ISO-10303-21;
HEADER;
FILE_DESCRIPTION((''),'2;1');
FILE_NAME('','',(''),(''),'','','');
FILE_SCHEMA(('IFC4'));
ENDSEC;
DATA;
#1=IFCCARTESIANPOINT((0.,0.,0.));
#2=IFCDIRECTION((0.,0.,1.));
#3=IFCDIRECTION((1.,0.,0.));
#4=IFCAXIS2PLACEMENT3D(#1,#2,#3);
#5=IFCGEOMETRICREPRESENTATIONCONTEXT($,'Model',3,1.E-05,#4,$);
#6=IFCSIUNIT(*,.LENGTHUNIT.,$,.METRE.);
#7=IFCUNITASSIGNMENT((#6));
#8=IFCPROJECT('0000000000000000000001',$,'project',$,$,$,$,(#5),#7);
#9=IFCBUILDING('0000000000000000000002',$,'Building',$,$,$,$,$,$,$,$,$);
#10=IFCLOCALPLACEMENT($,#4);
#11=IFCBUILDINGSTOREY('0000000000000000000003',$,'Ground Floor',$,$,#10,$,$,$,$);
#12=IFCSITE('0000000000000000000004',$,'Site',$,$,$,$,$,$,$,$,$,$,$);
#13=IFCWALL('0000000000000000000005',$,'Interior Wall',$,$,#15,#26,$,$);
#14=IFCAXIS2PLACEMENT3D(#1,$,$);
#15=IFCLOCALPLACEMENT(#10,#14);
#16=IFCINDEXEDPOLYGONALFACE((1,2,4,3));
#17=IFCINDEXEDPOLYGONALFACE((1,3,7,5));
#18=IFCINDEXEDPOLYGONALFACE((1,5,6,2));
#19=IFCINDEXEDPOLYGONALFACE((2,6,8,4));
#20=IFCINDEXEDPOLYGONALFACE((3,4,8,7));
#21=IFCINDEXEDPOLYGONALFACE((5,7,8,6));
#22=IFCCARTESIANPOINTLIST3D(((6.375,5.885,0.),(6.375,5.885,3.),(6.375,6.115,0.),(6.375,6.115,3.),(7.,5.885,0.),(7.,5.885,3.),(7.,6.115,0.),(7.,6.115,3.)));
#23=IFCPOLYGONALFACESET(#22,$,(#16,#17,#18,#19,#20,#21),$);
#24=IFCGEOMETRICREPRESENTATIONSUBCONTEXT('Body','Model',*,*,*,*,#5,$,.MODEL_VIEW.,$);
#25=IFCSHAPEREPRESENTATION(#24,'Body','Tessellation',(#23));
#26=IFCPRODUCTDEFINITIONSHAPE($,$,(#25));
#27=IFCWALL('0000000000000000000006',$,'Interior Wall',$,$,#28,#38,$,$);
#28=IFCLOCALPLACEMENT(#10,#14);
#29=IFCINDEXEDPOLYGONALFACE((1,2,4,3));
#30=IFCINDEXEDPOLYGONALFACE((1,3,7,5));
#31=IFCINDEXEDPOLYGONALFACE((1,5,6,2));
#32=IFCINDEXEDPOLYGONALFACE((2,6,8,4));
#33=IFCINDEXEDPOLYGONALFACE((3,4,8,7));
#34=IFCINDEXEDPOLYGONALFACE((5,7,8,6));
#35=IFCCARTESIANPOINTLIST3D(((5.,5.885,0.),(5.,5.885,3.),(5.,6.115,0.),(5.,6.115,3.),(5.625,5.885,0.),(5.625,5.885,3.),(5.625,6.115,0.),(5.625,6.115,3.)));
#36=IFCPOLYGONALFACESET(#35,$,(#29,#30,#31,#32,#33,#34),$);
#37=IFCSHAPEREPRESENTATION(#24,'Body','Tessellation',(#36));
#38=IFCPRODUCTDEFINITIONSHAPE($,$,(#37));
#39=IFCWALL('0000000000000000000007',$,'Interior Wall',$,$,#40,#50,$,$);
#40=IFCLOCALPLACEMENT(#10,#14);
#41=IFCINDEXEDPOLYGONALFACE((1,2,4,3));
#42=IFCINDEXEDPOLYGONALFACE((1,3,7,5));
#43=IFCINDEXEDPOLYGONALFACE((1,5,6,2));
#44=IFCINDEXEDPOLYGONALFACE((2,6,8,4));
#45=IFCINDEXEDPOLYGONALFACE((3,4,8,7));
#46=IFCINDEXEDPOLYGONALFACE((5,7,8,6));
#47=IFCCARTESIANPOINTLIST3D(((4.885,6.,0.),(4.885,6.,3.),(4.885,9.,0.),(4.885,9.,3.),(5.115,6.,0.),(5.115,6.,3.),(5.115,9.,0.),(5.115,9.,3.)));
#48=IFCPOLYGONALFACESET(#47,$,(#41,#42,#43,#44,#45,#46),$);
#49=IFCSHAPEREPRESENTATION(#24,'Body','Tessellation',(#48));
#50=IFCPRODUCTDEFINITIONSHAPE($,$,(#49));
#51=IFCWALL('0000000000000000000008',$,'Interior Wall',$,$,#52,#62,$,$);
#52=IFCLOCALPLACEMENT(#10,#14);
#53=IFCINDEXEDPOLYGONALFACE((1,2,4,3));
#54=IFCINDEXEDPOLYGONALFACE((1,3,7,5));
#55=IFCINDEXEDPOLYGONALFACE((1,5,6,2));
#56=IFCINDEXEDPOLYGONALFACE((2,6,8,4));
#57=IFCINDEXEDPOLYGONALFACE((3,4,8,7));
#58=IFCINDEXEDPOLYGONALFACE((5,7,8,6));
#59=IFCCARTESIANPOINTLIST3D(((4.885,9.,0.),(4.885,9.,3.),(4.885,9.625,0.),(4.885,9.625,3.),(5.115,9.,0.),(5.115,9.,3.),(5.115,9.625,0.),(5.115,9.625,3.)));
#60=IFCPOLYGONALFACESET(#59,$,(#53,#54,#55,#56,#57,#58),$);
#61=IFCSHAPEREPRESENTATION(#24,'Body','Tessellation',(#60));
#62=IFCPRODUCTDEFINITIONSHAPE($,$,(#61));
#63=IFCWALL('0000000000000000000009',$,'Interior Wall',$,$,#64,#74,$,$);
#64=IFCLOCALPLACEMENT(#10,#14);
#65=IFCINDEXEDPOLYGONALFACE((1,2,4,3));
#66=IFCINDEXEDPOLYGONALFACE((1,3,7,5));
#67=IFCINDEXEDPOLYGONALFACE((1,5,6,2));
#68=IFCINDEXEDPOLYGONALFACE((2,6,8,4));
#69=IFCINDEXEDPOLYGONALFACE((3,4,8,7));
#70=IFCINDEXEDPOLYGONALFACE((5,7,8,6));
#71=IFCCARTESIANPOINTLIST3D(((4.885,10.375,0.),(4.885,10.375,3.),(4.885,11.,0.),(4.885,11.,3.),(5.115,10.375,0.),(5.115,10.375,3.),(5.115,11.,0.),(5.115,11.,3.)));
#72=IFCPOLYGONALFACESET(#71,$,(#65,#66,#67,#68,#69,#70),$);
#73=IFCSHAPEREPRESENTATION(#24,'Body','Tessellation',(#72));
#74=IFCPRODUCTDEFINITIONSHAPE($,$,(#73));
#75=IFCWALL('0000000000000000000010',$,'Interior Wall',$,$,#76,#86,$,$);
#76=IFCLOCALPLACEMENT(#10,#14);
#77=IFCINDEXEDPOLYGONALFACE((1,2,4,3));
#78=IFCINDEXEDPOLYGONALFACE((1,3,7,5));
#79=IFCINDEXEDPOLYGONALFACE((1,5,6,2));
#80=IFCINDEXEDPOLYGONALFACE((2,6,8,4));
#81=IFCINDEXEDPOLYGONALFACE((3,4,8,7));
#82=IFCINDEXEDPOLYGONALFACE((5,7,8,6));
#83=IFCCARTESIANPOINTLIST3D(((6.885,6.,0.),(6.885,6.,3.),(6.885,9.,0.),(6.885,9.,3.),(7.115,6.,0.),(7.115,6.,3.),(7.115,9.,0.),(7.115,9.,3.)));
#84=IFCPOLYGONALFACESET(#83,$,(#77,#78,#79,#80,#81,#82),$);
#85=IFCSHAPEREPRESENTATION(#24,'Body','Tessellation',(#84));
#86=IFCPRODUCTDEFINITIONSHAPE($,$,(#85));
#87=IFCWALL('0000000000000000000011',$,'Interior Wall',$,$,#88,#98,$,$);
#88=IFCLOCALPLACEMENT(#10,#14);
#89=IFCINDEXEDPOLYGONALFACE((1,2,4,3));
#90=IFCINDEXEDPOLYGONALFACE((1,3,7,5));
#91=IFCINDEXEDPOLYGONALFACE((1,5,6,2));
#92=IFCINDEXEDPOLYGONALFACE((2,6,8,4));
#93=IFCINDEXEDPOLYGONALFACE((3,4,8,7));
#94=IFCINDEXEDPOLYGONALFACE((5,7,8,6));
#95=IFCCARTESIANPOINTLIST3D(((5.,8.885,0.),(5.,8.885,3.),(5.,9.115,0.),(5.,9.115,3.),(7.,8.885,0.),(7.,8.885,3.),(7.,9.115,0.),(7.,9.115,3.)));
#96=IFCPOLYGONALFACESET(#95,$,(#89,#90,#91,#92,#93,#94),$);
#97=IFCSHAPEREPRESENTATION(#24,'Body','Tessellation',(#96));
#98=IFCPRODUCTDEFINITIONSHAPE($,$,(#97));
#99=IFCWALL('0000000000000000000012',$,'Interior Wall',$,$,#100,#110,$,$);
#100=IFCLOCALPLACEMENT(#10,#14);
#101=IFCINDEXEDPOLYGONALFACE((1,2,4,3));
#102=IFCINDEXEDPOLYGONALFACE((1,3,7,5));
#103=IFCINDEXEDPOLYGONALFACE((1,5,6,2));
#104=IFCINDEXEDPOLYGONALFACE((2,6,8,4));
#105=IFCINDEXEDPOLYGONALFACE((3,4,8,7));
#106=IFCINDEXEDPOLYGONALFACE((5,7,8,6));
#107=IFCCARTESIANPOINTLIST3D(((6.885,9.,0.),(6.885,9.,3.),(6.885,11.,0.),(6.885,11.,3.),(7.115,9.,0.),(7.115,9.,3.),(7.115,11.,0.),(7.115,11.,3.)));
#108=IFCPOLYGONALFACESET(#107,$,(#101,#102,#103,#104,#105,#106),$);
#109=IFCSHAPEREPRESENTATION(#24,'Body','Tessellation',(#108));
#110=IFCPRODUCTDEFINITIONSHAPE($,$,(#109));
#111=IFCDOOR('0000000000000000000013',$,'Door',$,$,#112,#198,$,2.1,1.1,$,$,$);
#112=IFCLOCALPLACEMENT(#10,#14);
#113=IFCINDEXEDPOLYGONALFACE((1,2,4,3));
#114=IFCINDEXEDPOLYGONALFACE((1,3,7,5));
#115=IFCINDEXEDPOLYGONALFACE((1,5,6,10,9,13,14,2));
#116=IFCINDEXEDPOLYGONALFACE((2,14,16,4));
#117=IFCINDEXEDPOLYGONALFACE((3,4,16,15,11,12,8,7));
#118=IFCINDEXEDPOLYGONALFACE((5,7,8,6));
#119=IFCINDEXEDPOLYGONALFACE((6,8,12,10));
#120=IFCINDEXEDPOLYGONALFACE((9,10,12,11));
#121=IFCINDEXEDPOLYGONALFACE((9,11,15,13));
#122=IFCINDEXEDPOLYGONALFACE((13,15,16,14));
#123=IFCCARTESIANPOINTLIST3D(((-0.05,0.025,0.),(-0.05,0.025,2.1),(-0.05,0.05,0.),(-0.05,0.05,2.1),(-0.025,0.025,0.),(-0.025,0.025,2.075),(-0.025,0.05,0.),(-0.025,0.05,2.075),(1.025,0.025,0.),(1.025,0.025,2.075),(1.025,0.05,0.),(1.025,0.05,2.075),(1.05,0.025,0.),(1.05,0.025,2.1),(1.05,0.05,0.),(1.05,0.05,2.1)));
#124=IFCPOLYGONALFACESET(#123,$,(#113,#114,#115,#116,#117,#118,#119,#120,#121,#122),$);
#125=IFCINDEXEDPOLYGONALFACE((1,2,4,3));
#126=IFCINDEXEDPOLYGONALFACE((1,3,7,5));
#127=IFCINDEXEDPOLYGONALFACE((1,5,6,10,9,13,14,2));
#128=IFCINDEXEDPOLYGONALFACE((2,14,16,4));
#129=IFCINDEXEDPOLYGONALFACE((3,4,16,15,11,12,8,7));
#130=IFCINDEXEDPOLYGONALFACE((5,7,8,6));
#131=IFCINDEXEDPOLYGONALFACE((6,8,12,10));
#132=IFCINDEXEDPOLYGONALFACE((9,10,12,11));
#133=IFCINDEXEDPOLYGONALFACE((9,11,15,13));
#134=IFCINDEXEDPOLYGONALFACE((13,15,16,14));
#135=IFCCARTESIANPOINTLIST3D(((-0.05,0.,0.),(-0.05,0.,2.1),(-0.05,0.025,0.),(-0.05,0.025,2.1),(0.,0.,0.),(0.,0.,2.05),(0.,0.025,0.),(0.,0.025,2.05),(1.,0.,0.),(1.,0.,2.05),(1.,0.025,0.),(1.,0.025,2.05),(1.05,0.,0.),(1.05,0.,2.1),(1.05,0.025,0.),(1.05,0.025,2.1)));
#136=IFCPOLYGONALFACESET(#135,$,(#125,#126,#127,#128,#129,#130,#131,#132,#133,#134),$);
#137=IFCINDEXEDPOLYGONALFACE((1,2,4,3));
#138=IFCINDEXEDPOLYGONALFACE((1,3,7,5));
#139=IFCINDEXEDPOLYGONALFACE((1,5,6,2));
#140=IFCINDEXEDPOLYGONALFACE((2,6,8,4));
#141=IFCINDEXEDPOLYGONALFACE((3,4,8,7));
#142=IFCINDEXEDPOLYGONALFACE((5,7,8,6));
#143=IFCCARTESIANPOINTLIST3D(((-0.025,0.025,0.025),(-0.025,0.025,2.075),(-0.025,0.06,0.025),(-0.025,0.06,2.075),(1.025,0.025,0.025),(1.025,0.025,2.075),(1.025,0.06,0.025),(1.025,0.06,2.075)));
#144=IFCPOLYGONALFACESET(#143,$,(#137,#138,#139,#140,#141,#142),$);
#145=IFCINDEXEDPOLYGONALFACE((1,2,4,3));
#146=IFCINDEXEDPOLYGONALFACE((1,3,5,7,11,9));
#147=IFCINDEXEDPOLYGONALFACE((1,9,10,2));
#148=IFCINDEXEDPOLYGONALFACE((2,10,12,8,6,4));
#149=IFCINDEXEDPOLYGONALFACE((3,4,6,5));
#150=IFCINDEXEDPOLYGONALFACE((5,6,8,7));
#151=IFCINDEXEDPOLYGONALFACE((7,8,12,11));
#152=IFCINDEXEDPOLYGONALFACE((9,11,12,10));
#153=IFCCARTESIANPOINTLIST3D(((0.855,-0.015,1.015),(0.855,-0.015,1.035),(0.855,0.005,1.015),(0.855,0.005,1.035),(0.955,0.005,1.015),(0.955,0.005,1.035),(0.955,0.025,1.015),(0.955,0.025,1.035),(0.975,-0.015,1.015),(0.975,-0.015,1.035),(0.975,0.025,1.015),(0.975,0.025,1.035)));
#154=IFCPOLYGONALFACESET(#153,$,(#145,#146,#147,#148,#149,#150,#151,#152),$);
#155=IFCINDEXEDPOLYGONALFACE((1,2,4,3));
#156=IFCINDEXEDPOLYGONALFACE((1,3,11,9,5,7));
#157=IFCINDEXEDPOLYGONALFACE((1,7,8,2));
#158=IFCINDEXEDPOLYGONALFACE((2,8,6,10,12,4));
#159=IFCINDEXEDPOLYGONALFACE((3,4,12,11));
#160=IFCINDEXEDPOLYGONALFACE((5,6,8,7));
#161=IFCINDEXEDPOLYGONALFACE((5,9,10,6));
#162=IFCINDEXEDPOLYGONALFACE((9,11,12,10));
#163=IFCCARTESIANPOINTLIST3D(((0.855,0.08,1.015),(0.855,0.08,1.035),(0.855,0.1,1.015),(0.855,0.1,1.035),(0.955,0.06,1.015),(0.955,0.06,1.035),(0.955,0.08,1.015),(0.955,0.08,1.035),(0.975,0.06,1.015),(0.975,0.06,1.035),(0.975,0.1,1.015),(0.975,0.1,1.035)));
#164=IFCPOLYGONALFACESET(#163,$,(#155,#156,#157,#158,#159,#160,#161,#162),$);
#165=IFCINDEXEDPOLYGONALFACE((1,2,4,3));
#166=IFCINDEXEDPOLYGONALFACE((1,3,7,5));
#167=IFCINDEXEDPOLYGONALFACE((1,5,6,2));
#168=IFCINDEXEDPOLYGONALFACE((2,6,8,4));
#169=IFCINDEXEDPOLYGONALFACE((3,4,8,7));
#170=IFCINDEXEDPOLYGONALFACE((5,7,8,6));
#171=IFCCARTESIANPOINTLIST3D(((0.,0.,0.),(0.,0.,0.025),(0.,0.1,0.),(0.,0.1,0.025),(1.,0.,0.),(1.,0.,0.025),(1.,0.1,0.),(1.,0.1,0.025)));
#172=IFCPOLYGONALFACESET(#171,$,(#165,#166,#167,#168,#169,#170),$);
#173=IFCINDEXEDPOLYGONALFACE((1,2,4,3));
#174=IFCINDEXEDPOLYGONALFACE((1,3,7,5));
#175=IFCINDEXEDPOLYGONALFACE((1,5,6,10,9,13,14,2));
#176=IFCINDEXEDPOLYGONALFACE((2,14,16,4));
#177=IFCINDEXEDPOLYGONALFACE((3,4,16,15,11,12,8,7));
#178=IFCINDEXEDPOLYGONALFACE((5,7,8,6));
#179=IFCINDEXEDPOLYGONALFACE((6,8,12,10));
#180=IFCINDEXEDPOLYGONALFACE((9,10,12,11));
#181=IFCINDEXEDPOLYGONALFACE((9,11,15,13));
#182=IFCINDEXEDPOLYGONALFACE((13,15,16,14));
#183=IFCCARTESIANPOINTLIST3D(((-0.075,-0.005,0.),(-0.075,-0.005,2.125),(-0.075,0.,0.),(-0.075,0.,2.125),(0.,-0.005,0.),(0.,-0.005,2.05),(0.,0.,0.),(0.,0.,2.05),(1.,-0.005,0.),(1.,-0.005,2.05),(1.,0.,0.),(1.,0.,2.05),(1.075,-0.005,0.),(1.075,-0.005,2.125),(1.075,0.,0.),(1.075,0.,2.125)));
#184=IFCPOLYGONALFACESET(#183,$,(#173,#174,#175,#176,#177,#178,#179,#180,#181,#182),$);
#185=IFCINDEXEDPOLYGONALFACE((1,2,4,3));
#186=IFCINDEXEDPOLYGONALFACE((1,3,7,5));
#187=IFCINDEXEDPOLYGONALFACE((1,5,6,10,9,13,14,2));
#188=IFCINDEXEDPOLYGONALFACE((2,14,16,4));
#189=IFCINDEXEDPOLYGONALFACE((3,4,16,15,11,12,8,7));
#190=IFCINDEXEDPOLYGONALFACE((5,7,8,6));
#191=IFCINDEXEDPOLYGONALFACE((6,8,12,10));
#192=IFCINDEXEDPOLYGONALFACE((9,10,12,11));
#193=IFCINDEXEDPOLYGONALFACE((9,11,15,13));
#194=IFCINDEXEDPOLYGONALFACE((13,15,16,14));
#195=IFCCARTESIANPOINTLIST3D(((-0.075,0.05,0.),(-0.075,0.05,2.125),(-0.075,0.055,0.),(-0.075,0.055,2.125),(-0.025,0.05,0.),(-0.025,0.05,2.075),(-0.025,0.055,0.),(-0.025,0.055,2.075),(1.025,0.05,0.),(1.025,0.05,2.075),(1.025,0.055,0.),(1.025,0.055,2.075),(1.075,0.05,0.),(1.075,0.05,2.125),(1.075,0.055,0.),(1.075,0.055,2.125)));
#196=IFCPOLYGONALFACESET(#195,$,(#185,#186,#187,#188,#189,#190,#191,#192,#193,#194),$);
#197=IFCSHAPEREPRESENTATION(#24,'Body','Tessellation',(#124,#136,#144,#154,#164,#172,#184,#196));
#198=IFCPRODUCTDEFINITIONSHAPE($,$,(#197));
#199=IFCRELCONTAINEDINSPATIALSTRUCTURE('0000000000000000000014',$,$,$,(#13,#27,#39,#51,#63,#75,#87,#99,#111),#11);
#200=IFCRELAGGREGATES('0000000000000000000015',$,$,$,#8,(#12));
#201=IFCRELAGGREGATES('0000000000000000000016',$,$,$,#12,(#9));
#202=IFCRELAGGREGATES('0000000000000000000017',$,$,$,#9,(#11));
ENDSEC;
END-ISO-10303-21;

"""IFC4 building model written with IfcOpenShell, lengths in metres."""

from ifc_helpers import new_model, si_unit, frame, origin_with_axes, place, context, subcontext, project, spatial, line, indexed_curve, outline, extrude, element, save


model = new_model("IFC4")

# Units and contexts
model_context = context("Model", 3, precision=1e-05, world=origin_with_axes())
body_context = subcontext(model_context, "Body", "Model", "MODEL_VIEW")
ifc_project = project(units=[si_unit("LENGTHUNIT", "METRE")], contexts=[model_context])

# Site, building, storey
site = spatial("IfcSite", under=ifc_project, Name="Site")
building = spatial("IfcBuilding", under=site, Name="Building")
storey_placement = place(None, origin_with_axes())
storey = spatial("IfcBuildingStorey", under=building, at=storey_placement, Name="Ground Floor")

# Walls
for number, where, z_axis, x_axis, name in (
    (1, (7.0, 6.0, 0.0), (0.0, 0.0, 1.0), (-1.0, 0.0, 0.0), "Interior Wall"),
    (2, (5.625, 6.0, 0.0), (0.0, 0.0, 1.0), (-1.0, 0.0, 0.0), "Interior Wall"),
):
    element("IfcWall", number, at=place(storey_placement, frame(where, z_axis=z_axis, x_axis=x_axis)), inside=storey, Name=name, context=body_context, shape_type="SweptSolid", body=[
        extrude(outline(indexed_curve([(0.0, 0.0), (0.0, 0.23), (0.625, 0.23), (0.625, 0.0), (0.0, 0.0)], self_intersect=False)), frame((0.0, -0.115, 0.0), z_axis=(0.0, 0.0, 1.0), x_axis=(1.0, 0.0, 0.0)), (0.0, 0.0, 1.0), 3.0),
    ])
wall_1_placement = place(storey_placement, frame((5.0, 6.0, 0.0), z_axis=(0.0, 0.0, 1.0), x_axis=(0.0, 1.0, 0.0)))
element("IfcWall", 3, at=wall_1_placement, inside=storey, Name="Interior Wall", context=body_context, shape_type="SweptSolid", body=[
    extrude(outline(indexed_curve([(0.0, 0.0), (0.0, 0.23), (3.0, 0.23), (3.0, 0.0), (0.0, 0.0)], self_intersect=False)), frame((0.0, -0.115, 0.0), z_axis=(0.0, 0.0, 1.0), x_axis=(1.0, 0.0, 0.0)), (0.0, 0.0, 1.0), 3.0),
])
for number, where, z_axis, x_axis, name in (
    (4, (5.0, 9.0, 0.0), (0.0, 0.0, 1.0), (0.0, 1.0, 0.0), "Interior Wall"),
    (5, (5.0, 10.375, 0.0), (0.0, 0.0, 1.0), (0.0, 1.0, 0.0), "Interior Wall"),
):
    element("IfcWall", number, at=place(storey_placement, frame(where, z_axis=z_axis, x_axis=x_axis)), inside=storey, Name=name, context=body_context, shape_type="SweptSolid", body=[
        extrude(outline(indexed_curve([(0.0, 0.0), (0.0, 0.23), (0.625, 0.23), (0.625, 0.0), (0.0, 0.0)], self_intersect=False)), frame((0.0, -0.115, 0.0), z_axis=(0.0, 0.0, 1.0), x_axis=(1.0, 0.0, 0.0)), (0.0, 0.0, 1.0), 3.0),
    ])
wall_2_placement = place(storey_placement, frame((7.0, 6.0, 0.0), z_axis=(0.0, 0.0, 1.0), x_axis=(0.0, 1.0, 0.0)))
element("IfcWall", 6, at=wall_2_placement, inside=storey, Name="Interior Wall", context=body_context, shape_type="SweptSolid", body=[
    extrude(outline(indexed_curve([(0.0, 0.0), (0.0, 0.23), (3.0, 0.23), (3.0, 0.0), (0.0, 0.0)], self_intersect=False)), frame((0.0, -0.115, 0.0), z_axis=(0.0, 0.0, 1.0), x_axis=(1.0, 0.0, 0.0)), (0.0, 0.0, 1.0), 3.0),
])
for number, where, z_axis, x_axis, name in (
    (7, (7.0, 9.0, 0.0), (0.0, 0.0, 1.0), (-1.0, 0.0, 0.0), "Interior Wall"),
    (8, (7.0, 9.0, 0.0), (0.0, 0.0, 1.0), (0.0, 1.0, 0.0), "Interior Wall"),
):
    element("IfcWall", number, at=place(storey_placement, frame(where, z_axis=z_axis, x_axis=x_axis)), inside=storey, Name=name, context=body_context, shape_type="SweptSolid", body=[
        extrude(outline(indexed_curve([(0.0, 0.0), (0.0, 0.23), (2.0, 0.23), (2.0, 0.0), (0.0, 0.0)], self_intersect=False)), frame((0.0, -0.115, 0.0), z_axis=(0.0, 0.0, 1.0), x_axis=(1.0, 0.0, 0.0)), (0.0, 0.0, 1.0), 3.0),
    ])

# Door
door_1_placement = place(storey_placement, frame((-0.05, 0.0, 0.0), z_axis=(0.0, 0.0, 1.0), x_axis=(1.0, 0.0, 0.0)))
element("IfcDoor", 9, at=door_1_placement, inside=storey, Name="Door", OverallHeight=2.1, OverallWidth=1.1, context=body_context, shape_type="SweptSolid", body=[
    extrude(outline(indexed_curve([(0.0, 0.0), (0.0, 2.1), (1.1, 2.1), (1.1, 0.0), (1.075, 0.0), (1.075, 2.075), (0.025, 2.075), (0.025, 0.0)], segments=[line(1, 2, 3, 4, 5, 6, 7, 8, 1)])), frame((0.0, 0.025, 0.0), z_axis=(0.0, -1.0, 0.0), x_axis=(1.0, 0.0, 0.0)), (0.0, 0.0, -1.0), 0.025),
    extrude(outline(indexed_curve([(0.0, 0.0), (0.0, 2.1), (1.1, 2.1), (1.1, 0.0), (1.05, 0.0), (1.05, 2.05), (0.05, 2.05), (0.05, 0.0)], segments=[line(1, 2, 3, 4, 5, 6, 7, 8, 1)])), frame((0.0, 0.0, 0.0), z_axis=(0.0, -1.0, 0.0), x_axis=(1.0, 0.0, 0.0)), (0.0, 0.0, -1.0), 0.025),
    extrude(outline(indexed_curve([(0.0, 0.0), (1.05, 0.0), (1.05, 0.035), (0.0, 0.035)], segments=[line(1, 2, 3, 4, 1)])), frame((0.025, 0.025, 0.025), z_axis=(0.0, 0.0, 1.0), x_axis=(1.0, 0.0, 0.0)), (0.0, 0.0, 1.0), 2.05),
    extrude(outline(indexed_curve([(0.0, 0.0), (0.0, -0.04), (-0.12, -0.04), (-0.12, -0.02), (-0.02, -0.02), (-0.02, 0.0)], segments=[line(1, 2, 3, 4, 5, 6, 1)])), frame((1.025, 0.025, 1.015), z_axis=(0.0, 0.0, 1.0), x_axis=(1.0, 0.0, 0.0)), (0.0, 0.0, 1.0), 0.02),
    extrude(outline(indexed_curve([(0.0, 0.0), (0.0, 0.04), (-0.12, 0.04), (-0.12, 0.02), (-0.02, 0.02), (-0.02, 0.0)], segments=[line(1, 2, 3, 4, 5, 6, 1)])), frame((1.025, 0.06, 1.015), z_axis=(0.0, 0.0, 1.0), x_axis=(1.0, 0.0, 0.0)), (0.0, 0.0, 1.0), 0.02),
    extrude(outline(indexed_curve([(0.0, 0.0), (1.0, 0.0), (1.0, 0.1), (0.0, 0.1)], segments=[line(1, 2, 3, 4, 1)])), frame((0.05, 0.0, 0.0), z_axis=(0.0, 0.0, 1.0), x_axis=(1.0, 0.0, 0.0)), (0.0, 0.0, 1.0), 0.025),
    extrude(outline(indexed_curve([(0.0, 0.0), (0.0, 2.125), (1.15, 2.125), (1.15, 0.0), (1.075, 0.0), (1.075, 2.05), (0.075, 2.05), (0.075, 0.0)], segments=[line(1, 2, 3, 4, 5, 6, 7, 8, 1)])), frame((-0.025, -0.005, 0.0), z_axis=(0.0, -1.0, 0.0), x_axis=(1.0, 0.0, 0.0)), (0.0, 0.0, -1.0), 0.005),
    extrude(outline(indexed_curve([(0.0, 0.0), (0.0, 2.125), (1.15, 2.125), (1.15, 0.0), (1.1, 0.0), (1.1, 2.075), (0.05, 2.075), (0.05, 0.0)], segments=[line(1, 2, 3, 4, 5, 6, 7, 8, 1)])), frame((-0.025, 0.05, 0.0), z_axis=(0.0, -1.0, 0.0), x_axis=(1.0, 0.0, 0.0)), (0.0, 0.0, -1.0), 0.005),
])

save(model, "model.ifc")
